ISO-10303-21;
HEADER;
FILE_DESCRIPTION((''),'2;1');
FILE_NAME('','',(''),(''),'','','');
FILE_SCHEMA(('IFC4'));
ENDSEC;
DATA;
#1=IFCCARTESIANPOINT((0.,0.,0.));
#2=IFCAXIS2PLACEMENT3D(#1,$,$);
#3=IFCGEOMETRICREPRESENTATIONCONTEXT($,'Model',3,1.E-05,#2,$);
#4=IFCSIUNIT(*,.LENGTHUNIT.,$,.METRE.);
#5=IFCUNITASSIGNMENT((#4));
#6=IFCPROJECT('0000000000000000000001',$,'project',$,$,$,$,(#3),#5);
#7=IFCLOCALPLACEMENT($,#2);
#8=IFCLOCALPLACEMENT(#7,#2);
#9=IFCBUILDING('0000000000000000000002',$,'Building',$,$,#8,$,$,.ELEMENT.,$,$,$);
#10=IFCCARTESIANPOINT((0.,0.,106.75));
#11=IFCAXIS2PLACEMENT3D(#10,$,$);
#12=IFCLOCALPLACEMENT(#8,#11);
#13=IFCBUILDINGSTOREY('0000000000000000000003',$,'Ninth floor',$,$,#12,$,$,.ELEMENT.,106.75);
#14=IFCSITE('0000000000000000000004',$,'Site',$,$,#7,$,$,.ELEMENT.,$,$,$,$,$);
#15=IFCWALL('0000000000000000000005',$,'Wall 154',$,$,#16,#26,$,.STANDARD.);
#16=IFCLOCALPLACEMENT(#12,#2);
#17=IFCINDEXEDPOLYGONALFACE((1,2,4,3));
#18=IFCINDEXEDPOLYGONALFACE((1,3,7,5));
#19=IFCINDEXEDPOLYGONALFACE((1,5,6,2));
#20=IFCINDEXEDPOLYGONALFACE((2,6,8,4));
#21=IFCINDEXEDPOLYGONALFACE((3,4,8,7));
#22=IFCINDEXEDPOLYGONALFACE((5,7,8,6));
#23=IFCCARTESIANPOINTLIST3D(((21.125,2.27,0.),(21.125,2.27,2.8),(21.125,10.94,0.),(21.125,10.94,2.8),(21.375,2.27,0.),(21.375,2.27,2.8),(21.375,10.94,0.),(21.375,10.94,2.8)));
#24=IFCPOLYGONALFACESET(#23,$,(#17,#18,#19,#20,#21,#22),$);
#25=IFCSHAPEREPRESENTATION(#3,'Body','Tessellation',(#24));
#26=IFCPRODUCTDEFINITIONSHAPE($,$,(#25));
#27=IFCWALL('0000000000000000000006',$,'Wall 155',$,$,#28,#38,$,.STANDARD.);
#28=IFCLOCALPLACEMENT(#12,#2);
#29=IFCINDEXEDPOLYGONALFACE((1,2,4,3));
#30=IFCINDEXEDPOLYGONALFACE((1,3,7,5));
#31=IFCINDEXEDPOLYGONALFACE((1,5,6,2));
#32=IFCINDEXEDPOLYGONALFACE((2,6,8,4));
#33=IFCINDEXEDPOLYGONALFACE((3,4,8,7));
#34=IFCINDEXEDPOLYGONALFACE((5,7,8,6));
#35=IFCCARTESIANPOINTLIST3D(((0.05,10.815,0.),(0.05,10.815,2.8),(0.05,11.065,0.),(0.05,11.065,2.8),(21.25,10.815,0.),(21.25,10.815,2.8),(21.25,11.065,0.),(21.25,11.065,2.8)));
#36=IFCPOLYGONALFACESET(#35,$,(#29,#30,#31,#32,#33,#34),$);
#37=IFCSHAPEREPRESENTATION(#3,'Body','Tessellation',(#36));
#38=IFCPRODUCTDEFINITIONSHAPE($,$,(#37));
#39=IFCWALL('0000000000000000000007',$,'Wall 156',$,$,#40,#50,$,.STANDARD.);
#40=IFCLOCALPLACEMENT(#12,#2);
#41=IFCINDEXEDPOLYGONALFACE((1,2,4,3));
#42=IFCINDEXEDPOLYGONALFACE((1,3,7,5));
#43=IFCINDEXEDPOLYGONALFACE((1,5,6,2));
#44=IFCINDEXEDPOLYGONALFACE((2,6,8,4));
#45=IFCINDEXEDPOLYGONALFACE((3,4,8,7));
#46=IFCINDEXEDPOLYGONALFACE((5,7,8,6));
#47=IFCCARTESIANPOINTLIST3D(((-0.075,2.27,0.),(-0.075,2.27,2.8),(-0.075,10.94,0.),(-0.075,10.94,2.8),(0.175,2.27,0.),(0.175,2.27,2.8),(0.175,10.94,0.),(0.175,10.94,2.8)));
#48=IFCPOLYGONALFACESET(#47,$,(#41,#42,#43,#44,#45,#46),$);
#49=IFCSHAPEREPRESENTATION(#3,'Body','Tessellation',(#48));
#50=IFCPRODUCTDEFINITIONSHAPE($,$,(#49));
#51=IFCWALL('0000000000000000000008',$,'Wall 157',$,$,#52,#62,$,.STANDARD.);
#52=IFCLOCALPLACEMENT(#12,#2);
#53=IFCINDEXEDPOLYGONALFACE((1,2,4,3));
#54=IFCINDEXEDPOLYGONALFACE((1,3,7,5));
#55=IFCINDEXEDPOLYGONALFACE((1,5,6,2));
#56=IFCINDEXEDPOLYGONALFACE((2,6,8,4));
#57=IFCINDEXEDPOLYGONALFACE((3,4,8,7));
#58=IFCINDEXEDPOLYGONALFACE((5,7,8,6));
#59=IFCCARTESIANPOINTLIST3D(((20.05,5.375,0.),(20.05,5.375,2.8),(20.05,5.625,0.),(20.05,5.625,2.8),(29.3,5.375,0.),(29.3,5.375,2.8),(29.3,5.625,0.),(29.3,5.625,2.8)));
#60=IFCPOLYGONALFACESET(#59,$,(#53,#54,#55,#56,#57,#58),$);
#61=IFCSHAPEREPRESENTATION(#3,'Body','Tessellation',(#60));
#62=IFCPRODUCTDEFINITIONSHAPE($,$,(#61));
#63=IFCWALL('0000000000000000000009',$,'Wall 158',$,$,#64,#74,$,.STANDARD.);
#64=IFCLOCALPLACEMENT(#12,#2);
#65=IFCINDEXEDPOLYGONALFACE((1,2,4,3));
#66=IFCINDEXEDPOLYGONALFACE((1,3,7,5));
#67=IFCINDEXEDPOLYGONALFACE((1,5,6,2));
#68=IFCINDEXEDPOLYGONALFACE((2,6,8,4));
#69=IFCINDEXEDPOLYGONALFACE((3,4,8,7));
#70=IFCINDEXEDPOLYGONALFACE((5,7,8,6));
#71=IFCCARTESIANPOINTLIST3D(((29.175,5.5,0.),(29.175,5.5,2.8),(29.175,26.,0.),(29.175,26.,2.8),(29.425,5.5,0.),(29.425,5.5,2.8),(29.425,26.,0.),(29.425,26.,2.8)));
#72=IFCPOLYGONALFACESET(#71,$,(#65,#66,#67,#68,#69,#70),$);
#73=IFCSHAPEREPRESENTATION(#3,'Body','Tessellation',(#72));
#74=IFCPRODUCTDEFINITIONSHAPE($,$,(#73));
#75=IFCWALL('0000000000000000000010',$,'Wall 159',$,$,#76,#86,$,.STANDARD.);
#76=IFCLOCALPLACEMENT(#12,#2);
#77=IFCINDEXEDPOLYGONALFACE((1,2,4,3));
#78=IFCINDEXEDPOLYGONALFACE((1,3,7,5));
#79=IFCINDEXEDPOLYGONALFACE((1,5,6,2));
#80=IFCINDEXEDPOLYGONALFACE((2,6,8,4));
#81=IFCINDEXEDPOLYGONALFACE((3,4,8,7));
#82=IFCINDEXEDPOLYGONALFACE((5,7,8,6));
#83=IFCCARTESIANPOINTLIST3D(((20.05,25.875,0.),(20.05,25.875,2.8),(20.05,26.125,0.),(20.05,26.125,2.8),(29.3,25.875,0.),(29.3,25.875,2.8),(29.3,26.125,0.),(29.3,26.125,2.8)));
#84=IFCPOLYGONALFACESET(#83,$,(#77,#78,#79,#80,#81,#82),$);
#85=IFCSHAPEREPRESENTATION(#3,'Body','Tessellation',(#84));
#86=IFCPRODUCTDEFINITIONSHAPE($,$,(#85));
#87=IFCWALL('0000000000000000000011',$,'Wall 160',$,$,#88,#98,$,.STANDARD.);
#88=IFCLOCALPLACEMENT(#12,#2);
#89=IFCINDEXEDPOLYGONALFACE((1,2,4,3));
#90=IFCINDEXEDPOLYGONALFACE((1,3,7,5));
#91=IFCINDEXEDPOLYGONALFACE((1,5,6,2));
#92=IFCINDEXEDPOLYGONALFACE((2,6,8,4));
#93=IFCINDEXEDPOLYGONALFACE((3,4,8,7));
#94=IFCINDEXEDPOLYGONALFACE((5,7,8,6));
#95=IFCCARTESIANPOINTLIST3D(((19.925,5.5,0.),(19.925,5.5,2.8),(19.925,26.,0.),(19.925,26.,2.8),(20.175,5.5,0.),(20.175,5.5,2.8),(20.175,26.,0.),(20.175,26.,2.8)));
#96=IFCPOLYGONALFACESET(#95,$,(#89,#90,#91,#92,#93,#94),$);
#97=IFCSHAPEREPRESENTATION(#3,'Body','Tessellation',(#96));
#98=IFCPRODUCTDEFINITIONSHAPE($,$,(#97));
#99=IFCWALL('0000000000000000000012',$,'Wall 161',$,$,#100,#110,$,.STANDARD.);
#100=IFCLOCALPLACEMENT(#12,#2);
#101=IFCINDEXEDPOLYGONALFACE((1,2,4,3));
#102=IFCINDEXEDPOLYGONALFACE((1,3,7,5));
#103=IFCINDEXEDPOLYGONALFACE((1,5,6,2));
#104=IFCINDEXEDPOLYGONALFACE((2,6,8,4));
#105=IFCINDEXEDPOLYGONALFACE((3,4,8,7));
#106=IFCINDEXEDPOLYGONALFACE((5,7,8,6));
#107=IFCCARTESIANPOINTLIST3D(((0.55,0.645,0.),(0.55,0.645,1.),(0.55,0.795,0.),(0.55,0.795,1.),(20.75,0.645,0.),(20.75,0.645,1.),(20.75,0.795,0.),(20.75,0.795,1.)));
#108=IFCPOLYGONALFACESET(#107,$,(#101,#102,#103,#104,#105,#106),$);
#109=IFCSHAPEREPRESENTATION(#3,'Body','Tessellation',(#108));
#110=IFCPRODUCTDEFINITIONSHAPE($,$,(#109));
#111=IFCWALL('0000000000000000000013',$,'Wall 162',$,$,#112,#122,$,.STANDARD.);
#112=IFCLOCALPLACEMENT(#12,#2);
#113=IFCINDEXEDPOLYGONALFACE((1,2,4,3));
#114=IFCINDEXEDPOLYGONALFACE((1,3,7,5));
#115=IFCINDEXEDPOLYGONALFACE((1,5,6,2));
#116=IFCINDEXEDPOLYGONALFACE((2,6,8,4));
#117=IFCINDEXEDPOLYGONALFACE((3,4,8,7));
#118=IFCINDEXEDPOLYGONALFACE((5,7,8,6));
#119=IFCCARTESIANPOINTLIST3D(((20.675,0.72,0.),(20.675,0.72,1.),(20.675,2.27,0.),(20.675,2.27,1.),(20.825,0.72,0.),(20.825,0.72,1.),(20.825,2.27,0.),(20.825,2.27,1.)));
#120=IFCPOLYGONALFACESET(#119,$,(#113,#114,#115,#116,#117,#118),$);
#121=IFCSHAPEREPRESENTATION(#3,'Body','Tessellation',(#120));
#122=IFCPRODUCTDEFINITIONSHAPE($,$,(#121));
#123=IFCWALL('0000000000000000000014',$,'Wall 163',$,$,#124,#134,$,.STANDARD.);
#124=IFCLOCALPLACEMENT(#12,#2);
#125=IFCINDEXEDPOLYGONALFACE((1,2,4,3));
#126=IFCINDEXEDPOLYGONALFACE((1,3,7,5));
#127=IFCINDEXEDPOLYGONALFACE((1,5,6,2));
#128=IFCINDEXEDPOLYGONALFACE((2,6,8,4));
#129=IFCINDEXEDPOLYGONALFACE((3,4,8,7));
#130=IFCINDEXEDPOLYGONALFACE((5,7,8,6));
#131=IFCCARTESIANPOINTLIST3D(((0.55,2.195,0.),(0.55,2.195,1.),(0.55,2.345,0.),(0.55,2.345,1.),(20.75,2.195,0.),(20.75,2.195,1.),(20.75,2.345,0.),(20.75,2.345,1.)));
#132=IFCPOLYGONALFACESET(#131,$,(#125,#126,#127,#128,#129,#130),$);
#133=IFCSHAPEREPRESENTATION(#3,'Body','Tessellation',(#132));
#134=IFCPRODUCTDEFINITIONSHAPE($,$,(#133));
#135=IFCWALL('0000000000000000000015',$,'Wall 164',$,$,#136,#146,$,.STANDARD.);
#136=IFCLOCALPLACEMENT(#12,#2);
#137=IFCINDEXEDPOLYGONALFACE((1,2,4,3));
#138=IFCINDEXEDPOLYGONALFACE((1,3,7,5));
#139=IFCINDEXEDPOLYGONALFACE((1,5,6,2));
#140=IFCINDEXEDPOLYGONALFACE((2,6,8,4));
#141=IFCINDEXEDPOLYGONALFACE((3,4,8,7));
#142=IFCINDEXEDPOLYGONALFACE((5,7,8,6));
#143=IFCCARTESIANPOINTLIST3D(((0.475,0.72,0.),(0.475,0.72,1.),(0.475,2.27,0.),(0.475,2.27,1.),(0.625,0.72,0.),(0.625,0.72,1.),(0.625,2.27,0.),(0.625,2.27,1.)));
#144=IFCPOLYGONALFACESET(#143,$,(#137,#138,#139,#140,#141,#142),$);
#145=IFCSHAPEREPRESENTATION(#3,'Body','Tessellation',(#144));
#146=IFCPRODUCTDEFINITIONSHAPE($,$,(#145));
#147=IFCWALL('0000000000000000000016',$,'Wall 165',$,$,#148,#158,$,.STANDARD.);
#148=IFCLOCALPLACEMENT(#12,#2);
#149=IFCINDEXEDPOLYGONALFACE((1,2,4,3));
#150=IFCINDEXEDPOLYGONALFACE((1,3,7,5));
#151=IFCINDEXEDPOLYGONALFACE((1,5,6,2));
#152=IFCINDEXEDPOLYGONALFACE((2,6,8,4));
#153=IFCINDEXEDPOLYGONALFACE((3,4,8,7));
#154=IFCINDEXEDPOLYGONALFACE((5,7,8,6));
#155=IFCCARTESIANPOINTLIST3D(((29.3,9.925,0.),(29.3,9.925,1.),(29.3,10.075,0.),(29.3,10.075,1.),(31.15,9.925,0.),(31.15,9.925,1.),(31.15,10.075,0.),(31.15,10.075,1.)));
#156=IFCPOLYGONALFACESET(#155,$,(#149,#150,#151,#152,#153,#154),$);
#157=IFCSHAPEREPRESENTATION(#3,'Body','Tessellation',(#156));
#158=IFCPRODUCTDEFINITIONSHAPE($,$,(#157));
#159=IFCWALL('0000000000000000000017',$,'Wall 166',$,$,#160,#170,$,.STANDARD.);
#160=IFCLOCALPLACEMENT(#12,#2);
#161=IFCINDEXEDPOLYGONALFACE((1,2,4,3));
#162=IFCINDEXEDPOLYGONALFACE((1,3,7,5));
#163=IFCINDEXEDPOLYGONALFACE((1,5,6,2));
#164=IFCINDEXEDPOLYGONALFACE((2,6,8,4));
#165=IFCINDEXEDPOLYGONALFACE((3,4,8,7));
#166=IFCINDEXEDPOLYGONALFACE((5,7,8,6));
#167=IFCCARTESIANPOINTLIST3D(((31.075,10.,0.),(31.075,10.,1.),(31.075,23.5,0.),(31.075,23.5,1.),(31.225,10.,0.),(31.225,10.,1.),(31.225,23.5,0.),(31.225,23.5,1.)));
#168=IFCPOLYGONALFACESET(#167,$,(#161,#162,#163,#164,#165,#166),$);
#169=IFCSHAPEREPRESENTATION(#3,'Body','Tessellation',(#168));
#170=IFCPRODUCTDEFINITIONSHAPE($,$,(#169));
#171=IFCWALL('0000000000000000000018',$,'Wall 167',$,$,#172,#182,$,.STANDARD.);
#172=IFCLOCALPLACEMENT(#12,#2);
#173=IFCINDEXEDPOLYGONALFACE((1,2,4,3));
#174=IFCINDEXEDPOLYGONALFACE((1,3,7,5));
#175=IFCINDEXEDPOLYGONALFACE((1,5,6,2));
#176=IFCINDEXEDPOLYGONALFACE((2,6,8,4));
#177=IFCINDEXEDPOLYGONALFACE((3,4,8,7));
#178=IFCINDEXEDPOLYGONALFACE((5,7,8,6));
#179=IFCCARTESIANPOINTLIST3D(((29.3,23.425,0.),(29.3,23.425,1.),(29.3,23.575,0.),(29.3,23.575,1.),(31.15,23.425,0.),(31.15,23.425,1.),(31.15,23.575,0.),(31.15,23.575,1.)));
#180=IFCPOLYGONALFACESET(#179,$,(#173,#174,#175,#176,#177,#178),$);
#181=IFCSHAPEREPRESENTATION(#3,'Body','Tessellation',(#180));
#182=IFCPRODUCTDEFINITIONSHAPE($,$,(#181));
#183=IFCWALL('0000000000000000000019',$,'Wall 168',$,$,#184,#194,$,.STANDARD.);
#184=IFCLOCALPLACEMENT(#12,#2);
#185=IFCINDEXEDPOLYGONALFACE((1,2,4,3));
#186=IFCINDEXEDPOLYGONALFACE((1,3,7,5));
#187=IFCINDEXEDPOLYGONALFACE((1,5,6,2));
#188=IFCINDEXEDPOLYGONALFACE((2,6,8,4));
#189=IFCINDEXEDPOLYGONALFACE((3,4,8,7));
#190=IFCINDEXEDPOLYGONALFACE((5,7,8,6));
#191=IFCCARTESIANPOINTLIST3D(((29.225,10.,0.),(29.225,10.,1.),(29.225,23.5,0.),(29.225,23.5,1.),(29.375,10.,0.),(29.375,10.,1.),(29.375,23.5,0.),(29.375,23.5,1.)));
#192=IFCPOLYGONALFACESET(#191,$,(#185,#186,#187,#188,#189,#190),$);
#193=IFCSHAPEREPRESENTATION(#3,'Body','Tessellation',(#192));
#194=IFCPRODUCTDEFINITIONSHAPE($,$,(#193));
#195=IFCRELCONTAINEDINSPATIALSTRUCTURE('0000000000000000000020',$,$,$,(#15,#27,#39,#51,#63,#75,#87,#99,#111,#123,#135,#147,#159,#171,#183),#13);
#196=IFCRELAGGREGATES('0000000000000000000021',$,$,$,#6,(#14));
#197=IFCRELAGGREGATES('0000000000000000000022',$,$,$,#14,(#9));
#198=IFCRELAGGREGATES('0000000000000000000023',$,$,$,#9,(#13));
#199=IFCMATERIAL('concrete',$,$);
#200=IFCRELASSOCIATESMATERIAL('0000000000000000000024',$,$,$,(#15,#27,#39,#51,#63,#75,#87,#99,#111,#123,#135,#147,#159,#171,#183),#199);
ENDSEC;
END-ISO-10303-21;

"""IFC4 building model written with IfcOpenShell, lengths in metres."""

from ifc_helpers import new_model, si_unit, frame, frame_2d, origin, place, context, project, spatial, rectangle, extrude, material, element, save


model = new_model("IFC4")

# Units and contexts
model_context = context("Model", 3, precision=1e-05, world=origin())
ifc_project = project(units=[si_unit("LENGTHUNIT", "METRE")], contexts=[model_context])

# Site, building, storey
site_placement = place(None, origin())
site = spatial("IfcSite", under=ifc_project, at=site_placement, Name="Site", CompositionType="ELEMENT")
building_placement = place(site_placement, origin())
building = spatial("IfcBuilding", under=site, at=building_placement, Name="Building", CompositionType="ELEMENT")
storey_placement = place(building_placement, frame((0.0, 0.0, 106.75)))
storey = spatial("IfcBuildingStorey", under=building, at=storey_placement, Name="Ninth floor", CompositionType="ELEMENT", Elevation=106.75)

# Shared definitions
ifc_material = material(Name="concrete")

# Walls
wall_1_placement = place(storey_placement, frame((21.25, 2.27, 0.0), z_axis=(0.0, 0.0, 1.0), x_axis=(0.0, 1.0, 0.0)))
element("IfcWall", 1, at=wall_1_placement, inside=storey, material=ifc_material, Name="Wall 154", PredefinedType="STANDARD", context=model_context, shape_type="SweptSolid", body=[
    extrude(rectangle(XDim=8.67, YDim=0.25, at=frame_2d((4.335, 0.0))), origin(), (0.0, 0.0, 1.0), 2.8),
])
wall_2_placement = place(storey_placement, frame((21.25, 10.94, 0.0), z_axis=(0.0, 0.0, 1.0), x_axis=(-1.0, 0.0, 0.0)))
element("IfcWall", 2, at=wall_2_placement, inside=storey, material=ifc_material, Name="Wall 155", PredefinedType="STANDARD", context=model_context, shape_type="SweptSolid", body=[
    extrude(rectangle(XDim=21.2, YDim=0.25, at=frame_2d((10.6, 0.0))), origin(), (0.0, 0.0, 1.0), 2.8),
])
wall_3_placement = place(storey_placement, frame((0.05, 10.94, 0.0), z_axis=(0.0, 0.0, 1.0), x_axis=(0.0, -1.0, 0.0)))
element("IfcWall", 3, at=wall_3_placement, inside=storey, material=ifc_material, Name="Wall 156", PredefinedType="STANDARD", context=model_context, shape_type="SweptSolid", body=[
    extrude(rectangle(XDim=8.67, YDim=0.25, at=frame_2d((4.335, 0.0))), origin(), (0.0, 0.0, 1.0), 2.8),
])
wall_4_placement = place(storey_placement, frame((20.05, 5.5, 0.0), z_axis=(0.0, 0.0, 1.0), x_axis=(1.0, 0.0, 0.0)))
element("IfcWall", 4, at=wall_4_placement, inside=storey, material=ifc_material, Name="Wall 157", PredefinedType="STANDARD", context=model_context, shape_type="SweptSolid", body=[
    extrude(rectangle(XDim=9.25, YDim=0.25, at=frame_2d((4.625, 0.0))), origin(), (0.0, 0.0, 1.0), 2.8),
])
wall_5_placement = place(storey_placement, frame((29.3, 5.5, 0.0), z_axis=(0.0, 0.0, 1.0), x_axis=(0.0, 1.0, 0.0)))
element("IfcWall", 5, at=wall_5_placement, inside=storey, material=ifc_material, Name="Wall 158", PredefinedType="STANDARD", context=model_context, shape_type="SweptSolid", body=[
    extrude(rectangle(XDim=20.5, YDim=0.25, at=frame_2d((10.25, 0.0))), origin(), (0.0, 0.0, 1.0), 2.8),
])
wall_6_placement = place(storey_placement, frame((29.3, 26.0, 0.0), z_axis=(0.0, 0.0, 1.0), x_axis=(-1.0, 0.0, 0.0)))
element("IfcWall", 6, at=wall_6_placement, inside=storey, material=ifc_material, Name="Wall 159", PredefinedType="STANDARD", context=model_context, shape_type="SweptSolid", body=[
    extrude(rectangle(XDim=9.25, YDim=0.25, at=frame_2d((4.625, 0.0))), origin(), (0.0, 0.0, 1.0), 2.8),
])
wall_7_placement = place(storey_placement, frame((20.05, 26.0, 0.0), z_axis=(0.0, 0.0, 1.0), x_axis=(0.0, -1.0, 0.0)))
element("IfcWall", 7, at=wall_7_placement, inside=storey, material=ifc_material, Name="Wall 160", PredefinedType="STANDARD", context=model_context, shape_type="SweptSolid", body=[
    extrude(rectangle(XDim=20.5, YDim=0.25, at=frame_2d((10.25, 0.0))), origin(), (0.0, 0.0, 1.0), 2.8),
])
wall_8_placement = place(storey_placement, frame((0.55, 0.72, 0.0), z_axis=(0.0, 0.0, 1.0), x_axis=(1.0, 0.0, 0.0)))
element("IfcWall", 8, at=wall_8_placement, inside=storey, material=ifc_material, Name="Wall 161", PredefinedType="STANDARD", context=model_context, shape_type="SweptSolid", body=[
    extrude(rectangle(XDim=20.2, YDim=0.15, at=frame_2d((10.1, 0.0))), origin(), (0.0, 0.0, 1.0), 1.0),
])
wall_9_placement = place(storey_placement, frame((20.75, 0.72, 0.0), z_axis=(0.0, 0.0, 1.0), x_axis=(0.0, 1.0, 0.0)))
element("IfcWall", 9, at=wall_9_placement, inside=storey, material=ifc_material, Name="Wall 162", PredefinedType="STANDARD", context=model_context, shape_type="SweptSolid", body=[
    extrude(rectangle(XDim=1.55, YDim=0.15, at=frame_2d((0.775, 0.0))), origin(), (0.0, 0.0, 1.0), 1.0),
])
wall_10_placement = place(storey_placement, frame((20.75, 2.27, 0.0), z_axis=(0.0, 0.0, 1.0), x_axis=(-1.0, 0.0, 0.0)))
element("IfcWall", 10, at=wall_10_placement, inside=storey, material=ifc_material, Name="Wall 163", PredefinedType="STANDARD", context=model_context, shape_type="SweptSolid", body=[
    extrude(rectangle(XDim=20.2, YDim=0.15, at=frame_2d((10.1, 0.0))), origin(), (0.0, 0.0, 1.0), 1.0),
])
wall_11_placement = place(storey_placement, frame((0.55, 2.27, 0.0), z_axis=(0.0, 0.0, 1.0), x_axis=(0.0, -1.0, 0.0)))
element("IfcWall", 11, at=wall_11_placement, inside=storey, material=ifc_material, Name="Wall 164", PredefinedType="STANDARD", context=model_context, shape_type="SweptSolid", body=[
    extrude(rectangle(XDim=1.55, YDim=0.15, at=frame_2d((0.775, 0.0))), origin(), (0.0, 0.0, 1.0), 1.0),
])
wall_12_placement = place(storey_placement, frame((29.3, 10.0, 0.0), z_axis=(0.0, 0.0, 1.0), x_axis=(1.0, 0.0, 0.0)))
element("IfcWall", 12, at=wall_12_placement, inside=storey, material=ifc_material, Name="Wall 165", PredefinedType="STANDARD", context=model_context, shape_type="SweptSolid", body=[
    extrude(rectangle(XDim=1.85, YDim=0.15, at=frame_2d((0.925, 0.0))), origin(), (0.0, 0.0, 1.0), 1.0),
])
wall_13_placement = place(storey_placement, frame((31.15, 10.0, 0.0), z_axis=(0.0, 0.0, 1.0), x_axis=(0.0, 1.0, 0.0)))
element("IfcWall", 13, at=wall_13_placement, inside=storey, material=ifc_material, Name="Wall 166", PredefinedType="STANDARD", context=model_context, shape_type="SweptSolid", body=[
    extrude(rectangle(XDim=13.5, YDim=0.15, at=frame_2d((6.75, 0.0))), origin(), (0.0, 0.0, 1.0), 1.0),
])
wall_14_placement = place(storey_placement, frame((31.15, 23.5, 0.0), z_axis=(0.0, 0.0, 1.0), x_axis=(-1.0, 0.0, 0.0)))
element("IfcWall", 14, at=wall_14_placement, inside=storey, material=ifc_material, Name="Wall 167", PredefinedType="STANDARD", context=model_context, shape_type="SweptSolid", body=[
    extrude(rectangle(XDim=1.85, YDim=0.15, at=frame_2d((0.925, 0.0))), origin(), (0.0, 0.0, 1.0), 1.0),
])
wall_15_placement = place(storey_placement, frame((29.3, 23.5, 0.0), z_axis=(0.0, 0.0, 1.0), x_axis=(0.0, -1.0, 0.0)))
element("IfcWall", 15, at=wall_15_placement, inside=storey, material=ifc_material, Name="Wall 168", PredefinedType="STANDARD", context=model_context, shape_type="SweptSolid", body=[
    extrude(rectangle(XDim=13.5, YDim=0.15, at=frame_2d((6.75, 0.0))), origin(), (0.0, 0.0, 1.0), 1.0),
])

save(model, "model.ifc")
